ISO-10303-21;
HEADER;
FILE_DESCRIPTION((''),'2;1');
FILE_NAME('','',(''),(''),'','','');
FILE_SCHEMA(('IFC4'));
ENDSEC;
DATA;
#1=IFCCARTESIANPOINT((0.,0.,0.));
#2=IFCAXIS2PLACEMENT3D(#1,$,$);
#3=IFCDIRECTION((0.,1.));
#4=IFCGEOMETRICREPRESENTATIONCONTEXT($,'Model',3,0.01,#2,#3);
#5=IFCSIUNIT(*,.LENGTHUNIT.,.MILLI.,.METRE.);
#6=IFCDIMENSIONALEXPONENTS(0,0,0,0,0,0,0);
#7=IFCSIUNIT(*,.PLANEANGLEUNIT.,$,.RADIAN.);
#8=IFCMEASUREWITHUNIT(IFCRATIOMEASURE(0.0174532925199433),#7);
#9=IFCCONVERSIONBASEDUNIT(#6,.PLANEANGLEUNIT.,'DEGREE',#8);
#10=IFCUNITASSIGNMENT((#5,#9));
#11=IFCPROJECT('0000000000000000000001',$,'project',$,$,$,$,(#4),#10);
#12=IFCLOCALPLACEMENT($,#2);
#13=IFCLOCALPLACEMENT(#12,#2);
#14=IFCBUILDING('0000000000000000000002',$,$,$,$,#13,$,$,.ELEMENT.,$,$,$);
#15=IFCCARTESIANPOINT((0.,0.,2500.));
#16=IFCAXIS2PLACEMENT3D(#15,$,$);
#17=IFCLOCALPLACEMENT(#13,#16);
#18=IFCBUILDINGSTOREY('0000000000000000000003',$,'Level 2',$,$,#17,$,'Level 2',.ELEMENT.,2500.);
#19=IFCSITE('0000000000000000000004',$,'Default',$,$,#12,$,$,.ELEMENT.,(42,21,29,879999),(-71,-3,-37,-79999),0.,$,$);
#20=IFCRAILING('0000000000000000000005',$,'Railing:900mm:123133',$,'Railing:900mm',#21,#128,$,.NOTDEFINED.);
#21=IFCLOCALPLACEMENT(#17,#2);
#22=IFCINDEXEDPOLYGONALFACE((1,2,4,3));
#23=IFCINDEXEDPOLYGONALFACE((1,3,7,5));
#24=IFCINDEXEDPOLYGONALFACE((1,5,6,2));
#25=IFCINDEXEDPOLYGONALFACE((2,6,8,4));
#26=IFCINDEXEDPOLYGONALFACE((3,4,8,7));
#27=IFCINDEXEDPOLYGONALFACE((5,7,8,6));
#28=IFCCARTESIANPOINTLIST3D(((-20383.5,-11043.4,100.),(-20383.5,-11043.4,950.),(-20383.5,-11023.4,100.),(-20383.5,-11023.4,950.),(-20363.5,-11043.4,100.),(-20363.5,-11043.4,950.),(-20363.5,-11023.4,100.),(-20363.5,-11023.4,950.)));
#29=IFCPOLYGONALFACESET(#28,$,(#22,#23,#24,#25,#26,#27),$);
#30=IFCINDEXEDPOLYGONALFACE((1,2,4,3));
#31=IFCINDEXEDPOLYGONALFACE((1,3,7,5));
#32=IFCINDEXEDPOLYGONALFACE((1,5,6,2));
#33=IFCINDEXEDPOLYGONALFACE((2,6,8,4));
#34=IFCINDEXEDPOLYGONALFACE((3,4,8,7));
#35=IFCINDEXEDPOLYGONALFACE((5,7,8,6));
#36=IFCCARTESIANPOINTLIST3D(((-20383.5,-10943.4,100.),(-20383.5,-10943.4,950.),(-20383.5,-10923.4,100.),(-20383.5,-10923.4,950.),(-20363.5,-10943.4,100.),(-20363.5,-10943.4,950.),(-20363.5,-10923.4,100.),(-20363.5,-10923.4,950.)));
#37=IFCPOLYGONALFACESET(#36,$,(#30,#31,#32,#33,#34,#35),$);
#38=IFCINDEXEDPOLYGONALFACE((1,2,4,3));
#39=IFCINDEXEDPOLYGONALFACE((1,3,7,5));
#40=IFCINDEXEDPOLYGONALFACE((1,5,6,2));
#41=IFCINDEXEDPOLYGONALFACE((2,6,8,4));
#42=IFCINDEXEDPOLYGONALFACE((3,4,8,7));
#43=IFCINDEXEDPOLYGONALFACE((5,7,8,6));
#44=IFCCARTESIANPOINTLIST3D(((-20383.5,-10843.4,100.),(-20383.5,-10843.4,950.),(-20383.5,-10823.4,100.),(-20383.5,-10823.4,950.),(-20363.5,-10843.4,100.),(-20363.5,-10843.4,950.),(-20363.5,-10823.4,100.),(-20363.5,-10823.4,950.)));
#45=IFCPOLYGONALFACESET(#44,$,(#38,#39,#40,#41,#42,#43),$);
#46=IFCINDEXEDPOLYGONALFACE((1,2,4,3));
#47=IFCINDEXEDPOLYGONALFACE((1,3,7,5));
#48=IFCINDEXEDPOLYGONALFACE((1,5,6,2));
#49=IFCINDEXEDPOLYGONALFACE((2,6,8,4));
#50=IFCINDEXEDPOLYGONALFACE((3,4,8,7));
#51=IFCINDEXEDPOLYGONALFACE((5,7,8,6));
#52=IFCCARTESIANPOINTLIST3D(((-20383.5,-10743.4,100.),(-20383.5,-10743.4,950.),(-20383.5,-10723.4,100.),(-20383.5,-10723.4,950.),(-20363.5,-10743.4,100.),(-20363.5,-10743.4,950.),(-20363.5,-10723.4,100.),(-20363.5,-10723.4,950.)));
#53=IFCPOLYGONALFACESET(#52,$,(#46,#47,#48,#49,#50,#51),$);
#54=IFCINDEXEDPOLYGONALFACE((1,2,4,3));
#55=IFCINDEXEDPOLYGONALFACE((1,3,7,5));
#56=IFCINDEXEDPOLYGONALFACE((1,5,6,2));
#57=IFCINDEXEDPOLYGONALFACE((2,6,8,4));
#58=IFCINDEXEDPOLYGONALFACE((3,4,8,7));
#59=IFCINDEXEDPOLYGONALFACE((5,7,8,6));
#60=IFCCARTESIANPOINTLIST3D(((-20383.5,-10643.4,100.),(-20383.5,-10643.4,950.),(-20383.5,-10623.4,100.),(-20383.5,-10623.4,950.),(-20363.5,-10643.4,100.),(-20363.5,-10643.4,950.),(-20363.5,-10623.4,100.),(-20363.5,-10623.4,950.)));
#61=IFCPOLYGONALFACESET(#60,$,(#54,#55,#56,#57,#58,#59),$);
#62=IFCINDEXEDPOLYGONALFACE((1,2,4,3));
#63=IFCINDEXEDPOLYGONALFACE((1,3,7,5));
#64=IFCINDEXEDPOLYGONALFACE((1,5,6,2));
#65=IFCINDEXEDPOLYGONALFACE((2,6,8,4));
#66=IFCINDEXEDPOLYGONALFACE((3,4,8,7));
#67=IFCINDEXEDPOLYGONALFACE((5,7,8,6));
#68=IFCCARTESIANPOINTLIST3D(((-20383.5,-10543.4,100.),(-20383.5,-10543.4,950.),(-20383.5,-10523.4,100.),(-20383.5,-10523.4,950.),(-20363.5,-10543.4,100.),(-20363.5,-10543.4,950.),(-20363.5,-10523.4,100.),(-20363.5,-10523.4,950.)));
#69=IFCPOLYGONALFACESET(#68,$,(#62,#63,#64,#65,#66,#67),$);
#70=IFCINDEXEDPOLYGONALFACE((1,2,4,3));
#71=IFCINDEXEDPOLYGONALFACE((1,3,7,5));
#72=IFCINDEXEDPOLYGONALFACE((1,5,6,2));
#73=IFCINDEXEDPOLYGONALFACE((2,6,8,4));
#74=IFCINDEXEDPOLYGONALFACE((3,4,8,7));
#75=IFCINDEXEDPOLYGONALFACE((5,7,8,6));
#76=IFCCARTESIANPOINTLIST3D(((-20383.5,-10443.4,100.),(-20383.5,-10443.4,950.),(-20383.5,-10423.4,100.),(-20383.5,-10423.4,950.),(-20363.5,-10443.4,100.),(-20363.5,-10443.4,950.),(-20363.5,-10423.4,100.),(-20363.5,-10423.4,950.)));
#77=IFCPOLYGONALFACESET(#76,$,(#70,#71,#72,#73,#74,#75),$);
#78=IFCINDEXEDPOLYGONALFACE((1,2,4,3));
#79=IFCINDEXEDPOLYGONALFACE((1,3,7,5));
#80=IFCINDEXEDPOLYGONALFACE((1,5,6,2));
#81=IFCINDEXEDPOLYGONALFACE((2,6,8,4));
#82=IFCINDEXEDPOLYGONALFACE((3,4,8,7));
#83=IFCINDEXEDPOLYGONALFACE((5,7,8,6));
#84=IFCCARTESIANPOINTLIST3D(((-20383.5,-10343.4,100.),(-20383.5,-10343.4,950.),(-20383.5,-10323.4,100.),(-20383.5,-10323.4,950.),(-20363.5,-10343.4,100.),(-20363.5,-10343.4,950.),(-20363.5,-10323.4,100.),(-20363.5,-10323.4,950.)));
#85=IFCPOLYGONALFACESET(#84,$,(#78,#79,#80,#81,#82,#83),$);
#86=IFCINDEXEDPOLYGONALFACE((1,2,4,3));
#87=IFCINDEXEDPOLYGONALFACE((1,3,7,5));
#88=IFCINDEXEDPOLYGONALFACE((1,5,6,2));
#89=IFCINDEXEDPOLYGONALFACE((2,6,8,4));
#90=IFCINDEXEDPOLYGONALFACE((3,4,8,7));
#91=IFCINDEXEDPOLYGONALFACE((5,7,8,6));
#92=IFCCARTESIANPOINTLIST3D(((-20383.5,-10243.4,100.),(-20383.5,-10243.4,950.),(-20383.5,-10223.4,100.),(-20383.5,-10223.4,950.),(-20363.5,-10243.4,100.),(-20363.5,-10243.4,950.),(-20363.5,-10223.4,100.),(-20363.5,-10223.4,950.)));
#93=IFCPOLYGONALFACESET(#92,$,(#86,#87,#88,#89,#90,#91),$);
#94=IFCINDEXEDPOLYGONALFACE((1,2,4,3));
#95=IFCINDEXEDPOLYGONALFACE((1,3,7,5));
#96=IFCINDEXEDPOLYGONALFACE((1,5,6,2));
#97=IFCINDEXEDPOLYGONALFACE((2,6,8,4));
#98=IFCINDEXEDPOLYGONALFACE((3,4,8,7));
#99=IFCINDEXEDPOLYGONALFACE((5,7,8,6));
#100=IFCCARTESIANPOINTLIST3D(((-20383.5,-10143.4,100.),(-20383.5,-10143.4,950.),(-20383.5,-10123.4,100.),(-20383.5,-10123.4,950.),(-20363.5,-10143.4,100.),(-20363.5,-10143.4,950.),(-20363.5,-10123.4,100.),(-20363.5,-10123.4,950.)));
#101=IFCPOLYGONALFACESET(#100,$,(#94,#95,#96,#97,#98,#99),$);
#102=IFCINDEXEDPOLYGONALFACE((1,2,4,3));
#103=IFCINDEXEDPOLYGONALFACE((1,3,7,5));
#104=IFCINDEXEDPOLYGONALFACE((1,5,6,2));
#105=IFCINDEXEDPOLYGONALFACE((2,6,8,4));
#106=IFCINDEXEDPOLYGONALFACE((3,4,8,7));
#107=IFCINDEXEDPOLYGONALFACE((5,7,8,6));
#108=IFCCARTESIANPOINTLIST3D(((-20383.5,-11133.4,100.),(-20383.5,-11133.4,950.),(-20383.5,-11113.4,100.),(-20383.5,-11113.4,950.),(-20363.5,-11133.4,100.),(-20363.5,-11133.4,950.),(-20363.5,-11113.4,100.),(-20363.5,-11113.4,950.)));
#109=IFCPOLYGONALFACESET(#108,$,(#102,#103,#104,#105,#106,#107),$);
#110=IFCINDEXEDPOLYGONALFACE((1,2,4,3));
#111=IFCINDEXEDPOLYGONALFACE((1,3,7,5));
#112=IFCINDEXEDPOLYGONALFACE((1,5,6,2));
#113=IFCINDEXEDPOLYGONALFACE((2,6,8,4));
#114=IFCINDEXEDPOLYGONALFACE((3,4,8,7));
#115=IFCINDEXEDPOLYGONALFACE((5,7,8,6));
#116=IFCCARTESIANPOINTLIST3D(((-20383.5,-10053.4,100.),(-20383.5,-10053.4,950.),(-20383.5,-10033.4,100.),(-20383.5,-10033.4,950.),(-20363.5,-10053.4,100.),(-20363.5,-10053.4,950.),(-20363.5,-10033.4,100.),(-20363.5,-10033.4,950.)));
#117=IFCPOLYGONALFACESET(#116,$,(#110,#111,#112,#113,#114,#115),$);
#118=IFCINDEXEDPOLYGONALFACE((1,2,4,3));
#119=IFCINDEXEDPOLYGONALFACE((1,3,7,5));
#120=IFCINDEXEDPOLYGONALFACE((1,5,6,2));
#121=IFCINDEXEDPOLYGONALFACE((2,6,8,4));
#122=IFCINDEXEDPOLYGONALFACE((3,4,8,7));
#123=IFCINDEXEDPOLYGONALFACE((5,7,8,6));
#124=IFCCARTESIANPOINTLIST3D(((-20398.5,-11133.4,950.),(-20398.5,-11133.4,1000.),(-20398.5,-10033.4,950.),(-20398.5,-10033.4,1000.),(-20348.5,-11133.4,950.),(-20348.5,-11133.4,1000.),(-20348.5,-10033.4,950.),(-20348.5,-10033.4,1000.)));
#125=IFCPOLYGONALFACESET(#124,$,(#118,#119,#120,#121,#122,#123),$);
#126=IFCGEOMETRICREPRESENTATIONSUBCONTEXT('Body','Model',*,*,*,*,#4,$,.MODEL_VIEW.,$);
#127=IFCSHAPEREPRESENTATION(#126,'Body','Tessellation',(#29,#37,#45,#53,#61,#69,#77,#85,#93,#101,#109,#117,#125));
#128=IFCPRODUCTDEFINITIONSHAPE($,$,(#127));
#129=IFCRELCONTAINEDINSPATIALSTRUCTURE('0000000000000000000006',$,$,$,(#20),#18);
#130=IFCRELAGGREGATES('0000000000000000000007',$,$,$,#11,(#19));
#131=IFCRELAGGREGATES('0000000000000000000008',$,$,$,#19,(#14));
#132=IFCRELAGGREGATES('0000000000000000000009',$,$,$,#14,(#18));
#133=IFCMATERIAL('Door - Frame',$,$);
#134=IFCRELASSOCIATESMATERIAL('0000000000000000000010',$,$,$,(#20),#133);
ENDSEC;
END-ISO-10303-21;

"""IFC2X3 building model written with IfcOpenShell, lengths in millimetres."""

from ifc_helpers import new_model, entity, si_unit, converted_unit, direction, frame, frame_2d, origin, place, context, subcontext, project, spatial, rectangle, extrude, material, element, save


model = new_model("IFC2X3")

# Units and contexts
model_context = context("Model", 3, precision=0.01, world=origin(), true_north=direction((0.0, 1.0)))
body_context = subcontext(model_context, "Body", "Model", "MODEL_VIEW")
ifc_project = project(units=[si_unit("LENGTHUNIT", "METRE", prefix="MILLI"), converted_unit("PLANEANGLEUNIT", "DEGREE", entity("IfcRatioMeasure", 0.0174532925199433), si_unit("PLANEANGLEUNIT", "RADIAN"), dimensions=[0, 0, 0, 0, 0, 0, 0])], contexts=[model_context])

# Site, building, storey
site_placement = place(None, origin())
site = spatial("IfcSite", under=ifc_project, at=site_placement, Name="Default", CompositionType="ELEMENT", RefLatitude=(42, 21, 29, 879999), RefLongitude=(-71, -3, -37, -79999), RefElevation=0.0)
building_placement = place(site_placement, origin())
building = spatial("IfcBuilding", under=site, at=building_placement, CompositionType="ELEMENT")
storey_placement = place(building_placement, frame((0.0, 0.0, 2500.0)))
storey = spatial("IfcBuildingStorey", under=building, at=storey_placement, Name="Level 2", LongName="Level 2", CompositionType="ELEMENT", Elevation=2500.0)

# Shared definitions
ifc_material_1 = material(Name="Door - Frame")

# Railing
railing_placement = place(storey_placement, origin())
element("IfcRailing", 1, at=railing_placement, inside=storey, material=ifc_material_1, Name="Railing:900mm:123133", ObjectType="Railing:900mm", PredefinedType="NOTDEFINED", context=body_context, shape_type="SweptSolid", body=[
    extrude(rectangle(XDim=20.0, YDim=20.0, at=frame_2d((0.0, 0.0), x_axis=(1.0, 0.0))), frame((-20373.5, -11033.4, 100.0), z_axis=(0.0, 0.0, 1.0), x_axis=(0.0, -1.0, 0.0)), (0.0, 0.0, 1.0), 850.0),
    extrude(rectangle(XDim=20.0, YDim=20.0, at=frame_2d((0.0, 0.0), x_axis=(1.0, 0.0))), frame((-20373.5, -10933.4, 100.0), z_axis=(0.0, 0.0, 1.0), x_axis=(0.0, -1.0, 0.0)), (0.0, 0.0, 1.0), 850.0),
    extrude(rectangle(XDim=20.0, YDim=20.0, at=frame_2d((0.0, 0.0), x_axis=(1.0, 0.0))), frame((-20373.5, -10833.4, 100.0), z_axis=(0.0, 0.0, 1.0), x_axis=(0.0, -1.0, 0.0)), (0.0, 0.0, 1.0), 850.0),
    extrude(rectangle(XDim=20.0, YDim=20.0, at=frame_2d((0.0, 0.0), x_axis=(1.0, 0.0))), frame((-20373.5, -10733.4, 100.0), z_axis=(0.0, 0.0, 1.0), x_axis=(0.0, -1.0, 0.0)), (0.0, 0.0, 1.0), 850.0),
    extrude(rectangle(XDim=20.0, YDim=20.0, at=frame_2d((0.0, 0.0), x_axis=(1.0, 0.0))), frame((-20373.5, -10633.4, 100.0), z_axis=(0.0, 0.0, 1.0), x_axis=(0.0, -1.0, 0.0)), (0.0, 0.0, 1.0), 850.0),
    extrude(rectangle(XDim=20.0, YDim=20.0, at=frame_2d((0.0, 0.0), x_axis=(1.0, 0.0))), frame((-20373.5, -10533.4, 100.0), z_axis=(0.0, 0.0, 1.0), x_axis=(0.0, -1.0, 0.0)), (0.0, 0.0, 1.0), 850.0),
    extrude(rectangle(XDim=20.0, YDim=20.0, at=frame_2d((0.0, 0.0), x_axis=(1.0, 0.0))), frame((-20373.5, -10433.4, 100.0), z_axis=(0.0, 0.0, 1.0), x_axis=(0.0, -1.0, 0.0)), (0.0, 0.0, 1.0), 850.0),
    extrude(rectangle(XDim=20.0, YDim=20.0, at=frame_2d((0.0, 0.0), x_axis=(1.0, 0.0))), frame((-20373.5, -10333.4, 100.0), z_axis=(0.0, 0.0, 1.0), x_axis=(0.0, -1.0, 0.0)), (0.0, 0.0, 1.0), 850.0),
    extrude(rectangle(XDim=20.0, YDim=20.0, at=frame_2d((0.0, 0.0), x_axis=(1.0, 0.0))), frame((-20373.5, -10233.4, 100.0), z_axis=(0.0, 0.0, 1.0), x_axis=(0.0, -1.0, 0.0)), (0.0, 0.0, 1.0), 850.0),
    extrude(rectangle(XDim=20.0, YDim=20.0, at=frame_2d((0.0, 0.0), x_axis=(1.0, 0.0))), frame((-20373.5, -10133.4, 100.0), z_axis=(0.0, 0.0, 1.0), x_axis=(0.0, -1.0, 0.0)), (0.0, 0.0, 1.0), 850.0),
    extrude(rectangle(XDim=20.0, YDim=20.0, at=frame_2d((0.0, 0.0), x_axis=(1.0, 0.0))), frame((-20373.5, -11123.4, 100.0), z_axis=(0.0, 0.0, 1.0), x_axis=(0.0, -1.0, 0.0)), (0.0, 0.0, 1.0), 850.0),
    extrude(rectangle(XDim=20.0, YDim=20.0, at=frame_2d((0.0, 0.0), x_axis=(1.0, 0.0))), frame((-20373.5, -10043.4, 100.0), z_axis=(0.0, 0.0, 1.0), x_axis=(0.0, -1.0, 0.0)), (0.0, 0.0, 1.0), 850.0),
    extrude(rectangle(XDim=1100.0, YDim=50.0, at=frame_2d((0.0, 0.0), x_axis=(1.0, 0.0))), frame((-20373.5, -10583.4, 950.0), z_axis=(0.0, 0.0, 1.0), x_axis=(0.0, -1.0, 0.0)), (0.0, 0.0, 1.0), 50.0),
])

save(model, "model.ifc")
